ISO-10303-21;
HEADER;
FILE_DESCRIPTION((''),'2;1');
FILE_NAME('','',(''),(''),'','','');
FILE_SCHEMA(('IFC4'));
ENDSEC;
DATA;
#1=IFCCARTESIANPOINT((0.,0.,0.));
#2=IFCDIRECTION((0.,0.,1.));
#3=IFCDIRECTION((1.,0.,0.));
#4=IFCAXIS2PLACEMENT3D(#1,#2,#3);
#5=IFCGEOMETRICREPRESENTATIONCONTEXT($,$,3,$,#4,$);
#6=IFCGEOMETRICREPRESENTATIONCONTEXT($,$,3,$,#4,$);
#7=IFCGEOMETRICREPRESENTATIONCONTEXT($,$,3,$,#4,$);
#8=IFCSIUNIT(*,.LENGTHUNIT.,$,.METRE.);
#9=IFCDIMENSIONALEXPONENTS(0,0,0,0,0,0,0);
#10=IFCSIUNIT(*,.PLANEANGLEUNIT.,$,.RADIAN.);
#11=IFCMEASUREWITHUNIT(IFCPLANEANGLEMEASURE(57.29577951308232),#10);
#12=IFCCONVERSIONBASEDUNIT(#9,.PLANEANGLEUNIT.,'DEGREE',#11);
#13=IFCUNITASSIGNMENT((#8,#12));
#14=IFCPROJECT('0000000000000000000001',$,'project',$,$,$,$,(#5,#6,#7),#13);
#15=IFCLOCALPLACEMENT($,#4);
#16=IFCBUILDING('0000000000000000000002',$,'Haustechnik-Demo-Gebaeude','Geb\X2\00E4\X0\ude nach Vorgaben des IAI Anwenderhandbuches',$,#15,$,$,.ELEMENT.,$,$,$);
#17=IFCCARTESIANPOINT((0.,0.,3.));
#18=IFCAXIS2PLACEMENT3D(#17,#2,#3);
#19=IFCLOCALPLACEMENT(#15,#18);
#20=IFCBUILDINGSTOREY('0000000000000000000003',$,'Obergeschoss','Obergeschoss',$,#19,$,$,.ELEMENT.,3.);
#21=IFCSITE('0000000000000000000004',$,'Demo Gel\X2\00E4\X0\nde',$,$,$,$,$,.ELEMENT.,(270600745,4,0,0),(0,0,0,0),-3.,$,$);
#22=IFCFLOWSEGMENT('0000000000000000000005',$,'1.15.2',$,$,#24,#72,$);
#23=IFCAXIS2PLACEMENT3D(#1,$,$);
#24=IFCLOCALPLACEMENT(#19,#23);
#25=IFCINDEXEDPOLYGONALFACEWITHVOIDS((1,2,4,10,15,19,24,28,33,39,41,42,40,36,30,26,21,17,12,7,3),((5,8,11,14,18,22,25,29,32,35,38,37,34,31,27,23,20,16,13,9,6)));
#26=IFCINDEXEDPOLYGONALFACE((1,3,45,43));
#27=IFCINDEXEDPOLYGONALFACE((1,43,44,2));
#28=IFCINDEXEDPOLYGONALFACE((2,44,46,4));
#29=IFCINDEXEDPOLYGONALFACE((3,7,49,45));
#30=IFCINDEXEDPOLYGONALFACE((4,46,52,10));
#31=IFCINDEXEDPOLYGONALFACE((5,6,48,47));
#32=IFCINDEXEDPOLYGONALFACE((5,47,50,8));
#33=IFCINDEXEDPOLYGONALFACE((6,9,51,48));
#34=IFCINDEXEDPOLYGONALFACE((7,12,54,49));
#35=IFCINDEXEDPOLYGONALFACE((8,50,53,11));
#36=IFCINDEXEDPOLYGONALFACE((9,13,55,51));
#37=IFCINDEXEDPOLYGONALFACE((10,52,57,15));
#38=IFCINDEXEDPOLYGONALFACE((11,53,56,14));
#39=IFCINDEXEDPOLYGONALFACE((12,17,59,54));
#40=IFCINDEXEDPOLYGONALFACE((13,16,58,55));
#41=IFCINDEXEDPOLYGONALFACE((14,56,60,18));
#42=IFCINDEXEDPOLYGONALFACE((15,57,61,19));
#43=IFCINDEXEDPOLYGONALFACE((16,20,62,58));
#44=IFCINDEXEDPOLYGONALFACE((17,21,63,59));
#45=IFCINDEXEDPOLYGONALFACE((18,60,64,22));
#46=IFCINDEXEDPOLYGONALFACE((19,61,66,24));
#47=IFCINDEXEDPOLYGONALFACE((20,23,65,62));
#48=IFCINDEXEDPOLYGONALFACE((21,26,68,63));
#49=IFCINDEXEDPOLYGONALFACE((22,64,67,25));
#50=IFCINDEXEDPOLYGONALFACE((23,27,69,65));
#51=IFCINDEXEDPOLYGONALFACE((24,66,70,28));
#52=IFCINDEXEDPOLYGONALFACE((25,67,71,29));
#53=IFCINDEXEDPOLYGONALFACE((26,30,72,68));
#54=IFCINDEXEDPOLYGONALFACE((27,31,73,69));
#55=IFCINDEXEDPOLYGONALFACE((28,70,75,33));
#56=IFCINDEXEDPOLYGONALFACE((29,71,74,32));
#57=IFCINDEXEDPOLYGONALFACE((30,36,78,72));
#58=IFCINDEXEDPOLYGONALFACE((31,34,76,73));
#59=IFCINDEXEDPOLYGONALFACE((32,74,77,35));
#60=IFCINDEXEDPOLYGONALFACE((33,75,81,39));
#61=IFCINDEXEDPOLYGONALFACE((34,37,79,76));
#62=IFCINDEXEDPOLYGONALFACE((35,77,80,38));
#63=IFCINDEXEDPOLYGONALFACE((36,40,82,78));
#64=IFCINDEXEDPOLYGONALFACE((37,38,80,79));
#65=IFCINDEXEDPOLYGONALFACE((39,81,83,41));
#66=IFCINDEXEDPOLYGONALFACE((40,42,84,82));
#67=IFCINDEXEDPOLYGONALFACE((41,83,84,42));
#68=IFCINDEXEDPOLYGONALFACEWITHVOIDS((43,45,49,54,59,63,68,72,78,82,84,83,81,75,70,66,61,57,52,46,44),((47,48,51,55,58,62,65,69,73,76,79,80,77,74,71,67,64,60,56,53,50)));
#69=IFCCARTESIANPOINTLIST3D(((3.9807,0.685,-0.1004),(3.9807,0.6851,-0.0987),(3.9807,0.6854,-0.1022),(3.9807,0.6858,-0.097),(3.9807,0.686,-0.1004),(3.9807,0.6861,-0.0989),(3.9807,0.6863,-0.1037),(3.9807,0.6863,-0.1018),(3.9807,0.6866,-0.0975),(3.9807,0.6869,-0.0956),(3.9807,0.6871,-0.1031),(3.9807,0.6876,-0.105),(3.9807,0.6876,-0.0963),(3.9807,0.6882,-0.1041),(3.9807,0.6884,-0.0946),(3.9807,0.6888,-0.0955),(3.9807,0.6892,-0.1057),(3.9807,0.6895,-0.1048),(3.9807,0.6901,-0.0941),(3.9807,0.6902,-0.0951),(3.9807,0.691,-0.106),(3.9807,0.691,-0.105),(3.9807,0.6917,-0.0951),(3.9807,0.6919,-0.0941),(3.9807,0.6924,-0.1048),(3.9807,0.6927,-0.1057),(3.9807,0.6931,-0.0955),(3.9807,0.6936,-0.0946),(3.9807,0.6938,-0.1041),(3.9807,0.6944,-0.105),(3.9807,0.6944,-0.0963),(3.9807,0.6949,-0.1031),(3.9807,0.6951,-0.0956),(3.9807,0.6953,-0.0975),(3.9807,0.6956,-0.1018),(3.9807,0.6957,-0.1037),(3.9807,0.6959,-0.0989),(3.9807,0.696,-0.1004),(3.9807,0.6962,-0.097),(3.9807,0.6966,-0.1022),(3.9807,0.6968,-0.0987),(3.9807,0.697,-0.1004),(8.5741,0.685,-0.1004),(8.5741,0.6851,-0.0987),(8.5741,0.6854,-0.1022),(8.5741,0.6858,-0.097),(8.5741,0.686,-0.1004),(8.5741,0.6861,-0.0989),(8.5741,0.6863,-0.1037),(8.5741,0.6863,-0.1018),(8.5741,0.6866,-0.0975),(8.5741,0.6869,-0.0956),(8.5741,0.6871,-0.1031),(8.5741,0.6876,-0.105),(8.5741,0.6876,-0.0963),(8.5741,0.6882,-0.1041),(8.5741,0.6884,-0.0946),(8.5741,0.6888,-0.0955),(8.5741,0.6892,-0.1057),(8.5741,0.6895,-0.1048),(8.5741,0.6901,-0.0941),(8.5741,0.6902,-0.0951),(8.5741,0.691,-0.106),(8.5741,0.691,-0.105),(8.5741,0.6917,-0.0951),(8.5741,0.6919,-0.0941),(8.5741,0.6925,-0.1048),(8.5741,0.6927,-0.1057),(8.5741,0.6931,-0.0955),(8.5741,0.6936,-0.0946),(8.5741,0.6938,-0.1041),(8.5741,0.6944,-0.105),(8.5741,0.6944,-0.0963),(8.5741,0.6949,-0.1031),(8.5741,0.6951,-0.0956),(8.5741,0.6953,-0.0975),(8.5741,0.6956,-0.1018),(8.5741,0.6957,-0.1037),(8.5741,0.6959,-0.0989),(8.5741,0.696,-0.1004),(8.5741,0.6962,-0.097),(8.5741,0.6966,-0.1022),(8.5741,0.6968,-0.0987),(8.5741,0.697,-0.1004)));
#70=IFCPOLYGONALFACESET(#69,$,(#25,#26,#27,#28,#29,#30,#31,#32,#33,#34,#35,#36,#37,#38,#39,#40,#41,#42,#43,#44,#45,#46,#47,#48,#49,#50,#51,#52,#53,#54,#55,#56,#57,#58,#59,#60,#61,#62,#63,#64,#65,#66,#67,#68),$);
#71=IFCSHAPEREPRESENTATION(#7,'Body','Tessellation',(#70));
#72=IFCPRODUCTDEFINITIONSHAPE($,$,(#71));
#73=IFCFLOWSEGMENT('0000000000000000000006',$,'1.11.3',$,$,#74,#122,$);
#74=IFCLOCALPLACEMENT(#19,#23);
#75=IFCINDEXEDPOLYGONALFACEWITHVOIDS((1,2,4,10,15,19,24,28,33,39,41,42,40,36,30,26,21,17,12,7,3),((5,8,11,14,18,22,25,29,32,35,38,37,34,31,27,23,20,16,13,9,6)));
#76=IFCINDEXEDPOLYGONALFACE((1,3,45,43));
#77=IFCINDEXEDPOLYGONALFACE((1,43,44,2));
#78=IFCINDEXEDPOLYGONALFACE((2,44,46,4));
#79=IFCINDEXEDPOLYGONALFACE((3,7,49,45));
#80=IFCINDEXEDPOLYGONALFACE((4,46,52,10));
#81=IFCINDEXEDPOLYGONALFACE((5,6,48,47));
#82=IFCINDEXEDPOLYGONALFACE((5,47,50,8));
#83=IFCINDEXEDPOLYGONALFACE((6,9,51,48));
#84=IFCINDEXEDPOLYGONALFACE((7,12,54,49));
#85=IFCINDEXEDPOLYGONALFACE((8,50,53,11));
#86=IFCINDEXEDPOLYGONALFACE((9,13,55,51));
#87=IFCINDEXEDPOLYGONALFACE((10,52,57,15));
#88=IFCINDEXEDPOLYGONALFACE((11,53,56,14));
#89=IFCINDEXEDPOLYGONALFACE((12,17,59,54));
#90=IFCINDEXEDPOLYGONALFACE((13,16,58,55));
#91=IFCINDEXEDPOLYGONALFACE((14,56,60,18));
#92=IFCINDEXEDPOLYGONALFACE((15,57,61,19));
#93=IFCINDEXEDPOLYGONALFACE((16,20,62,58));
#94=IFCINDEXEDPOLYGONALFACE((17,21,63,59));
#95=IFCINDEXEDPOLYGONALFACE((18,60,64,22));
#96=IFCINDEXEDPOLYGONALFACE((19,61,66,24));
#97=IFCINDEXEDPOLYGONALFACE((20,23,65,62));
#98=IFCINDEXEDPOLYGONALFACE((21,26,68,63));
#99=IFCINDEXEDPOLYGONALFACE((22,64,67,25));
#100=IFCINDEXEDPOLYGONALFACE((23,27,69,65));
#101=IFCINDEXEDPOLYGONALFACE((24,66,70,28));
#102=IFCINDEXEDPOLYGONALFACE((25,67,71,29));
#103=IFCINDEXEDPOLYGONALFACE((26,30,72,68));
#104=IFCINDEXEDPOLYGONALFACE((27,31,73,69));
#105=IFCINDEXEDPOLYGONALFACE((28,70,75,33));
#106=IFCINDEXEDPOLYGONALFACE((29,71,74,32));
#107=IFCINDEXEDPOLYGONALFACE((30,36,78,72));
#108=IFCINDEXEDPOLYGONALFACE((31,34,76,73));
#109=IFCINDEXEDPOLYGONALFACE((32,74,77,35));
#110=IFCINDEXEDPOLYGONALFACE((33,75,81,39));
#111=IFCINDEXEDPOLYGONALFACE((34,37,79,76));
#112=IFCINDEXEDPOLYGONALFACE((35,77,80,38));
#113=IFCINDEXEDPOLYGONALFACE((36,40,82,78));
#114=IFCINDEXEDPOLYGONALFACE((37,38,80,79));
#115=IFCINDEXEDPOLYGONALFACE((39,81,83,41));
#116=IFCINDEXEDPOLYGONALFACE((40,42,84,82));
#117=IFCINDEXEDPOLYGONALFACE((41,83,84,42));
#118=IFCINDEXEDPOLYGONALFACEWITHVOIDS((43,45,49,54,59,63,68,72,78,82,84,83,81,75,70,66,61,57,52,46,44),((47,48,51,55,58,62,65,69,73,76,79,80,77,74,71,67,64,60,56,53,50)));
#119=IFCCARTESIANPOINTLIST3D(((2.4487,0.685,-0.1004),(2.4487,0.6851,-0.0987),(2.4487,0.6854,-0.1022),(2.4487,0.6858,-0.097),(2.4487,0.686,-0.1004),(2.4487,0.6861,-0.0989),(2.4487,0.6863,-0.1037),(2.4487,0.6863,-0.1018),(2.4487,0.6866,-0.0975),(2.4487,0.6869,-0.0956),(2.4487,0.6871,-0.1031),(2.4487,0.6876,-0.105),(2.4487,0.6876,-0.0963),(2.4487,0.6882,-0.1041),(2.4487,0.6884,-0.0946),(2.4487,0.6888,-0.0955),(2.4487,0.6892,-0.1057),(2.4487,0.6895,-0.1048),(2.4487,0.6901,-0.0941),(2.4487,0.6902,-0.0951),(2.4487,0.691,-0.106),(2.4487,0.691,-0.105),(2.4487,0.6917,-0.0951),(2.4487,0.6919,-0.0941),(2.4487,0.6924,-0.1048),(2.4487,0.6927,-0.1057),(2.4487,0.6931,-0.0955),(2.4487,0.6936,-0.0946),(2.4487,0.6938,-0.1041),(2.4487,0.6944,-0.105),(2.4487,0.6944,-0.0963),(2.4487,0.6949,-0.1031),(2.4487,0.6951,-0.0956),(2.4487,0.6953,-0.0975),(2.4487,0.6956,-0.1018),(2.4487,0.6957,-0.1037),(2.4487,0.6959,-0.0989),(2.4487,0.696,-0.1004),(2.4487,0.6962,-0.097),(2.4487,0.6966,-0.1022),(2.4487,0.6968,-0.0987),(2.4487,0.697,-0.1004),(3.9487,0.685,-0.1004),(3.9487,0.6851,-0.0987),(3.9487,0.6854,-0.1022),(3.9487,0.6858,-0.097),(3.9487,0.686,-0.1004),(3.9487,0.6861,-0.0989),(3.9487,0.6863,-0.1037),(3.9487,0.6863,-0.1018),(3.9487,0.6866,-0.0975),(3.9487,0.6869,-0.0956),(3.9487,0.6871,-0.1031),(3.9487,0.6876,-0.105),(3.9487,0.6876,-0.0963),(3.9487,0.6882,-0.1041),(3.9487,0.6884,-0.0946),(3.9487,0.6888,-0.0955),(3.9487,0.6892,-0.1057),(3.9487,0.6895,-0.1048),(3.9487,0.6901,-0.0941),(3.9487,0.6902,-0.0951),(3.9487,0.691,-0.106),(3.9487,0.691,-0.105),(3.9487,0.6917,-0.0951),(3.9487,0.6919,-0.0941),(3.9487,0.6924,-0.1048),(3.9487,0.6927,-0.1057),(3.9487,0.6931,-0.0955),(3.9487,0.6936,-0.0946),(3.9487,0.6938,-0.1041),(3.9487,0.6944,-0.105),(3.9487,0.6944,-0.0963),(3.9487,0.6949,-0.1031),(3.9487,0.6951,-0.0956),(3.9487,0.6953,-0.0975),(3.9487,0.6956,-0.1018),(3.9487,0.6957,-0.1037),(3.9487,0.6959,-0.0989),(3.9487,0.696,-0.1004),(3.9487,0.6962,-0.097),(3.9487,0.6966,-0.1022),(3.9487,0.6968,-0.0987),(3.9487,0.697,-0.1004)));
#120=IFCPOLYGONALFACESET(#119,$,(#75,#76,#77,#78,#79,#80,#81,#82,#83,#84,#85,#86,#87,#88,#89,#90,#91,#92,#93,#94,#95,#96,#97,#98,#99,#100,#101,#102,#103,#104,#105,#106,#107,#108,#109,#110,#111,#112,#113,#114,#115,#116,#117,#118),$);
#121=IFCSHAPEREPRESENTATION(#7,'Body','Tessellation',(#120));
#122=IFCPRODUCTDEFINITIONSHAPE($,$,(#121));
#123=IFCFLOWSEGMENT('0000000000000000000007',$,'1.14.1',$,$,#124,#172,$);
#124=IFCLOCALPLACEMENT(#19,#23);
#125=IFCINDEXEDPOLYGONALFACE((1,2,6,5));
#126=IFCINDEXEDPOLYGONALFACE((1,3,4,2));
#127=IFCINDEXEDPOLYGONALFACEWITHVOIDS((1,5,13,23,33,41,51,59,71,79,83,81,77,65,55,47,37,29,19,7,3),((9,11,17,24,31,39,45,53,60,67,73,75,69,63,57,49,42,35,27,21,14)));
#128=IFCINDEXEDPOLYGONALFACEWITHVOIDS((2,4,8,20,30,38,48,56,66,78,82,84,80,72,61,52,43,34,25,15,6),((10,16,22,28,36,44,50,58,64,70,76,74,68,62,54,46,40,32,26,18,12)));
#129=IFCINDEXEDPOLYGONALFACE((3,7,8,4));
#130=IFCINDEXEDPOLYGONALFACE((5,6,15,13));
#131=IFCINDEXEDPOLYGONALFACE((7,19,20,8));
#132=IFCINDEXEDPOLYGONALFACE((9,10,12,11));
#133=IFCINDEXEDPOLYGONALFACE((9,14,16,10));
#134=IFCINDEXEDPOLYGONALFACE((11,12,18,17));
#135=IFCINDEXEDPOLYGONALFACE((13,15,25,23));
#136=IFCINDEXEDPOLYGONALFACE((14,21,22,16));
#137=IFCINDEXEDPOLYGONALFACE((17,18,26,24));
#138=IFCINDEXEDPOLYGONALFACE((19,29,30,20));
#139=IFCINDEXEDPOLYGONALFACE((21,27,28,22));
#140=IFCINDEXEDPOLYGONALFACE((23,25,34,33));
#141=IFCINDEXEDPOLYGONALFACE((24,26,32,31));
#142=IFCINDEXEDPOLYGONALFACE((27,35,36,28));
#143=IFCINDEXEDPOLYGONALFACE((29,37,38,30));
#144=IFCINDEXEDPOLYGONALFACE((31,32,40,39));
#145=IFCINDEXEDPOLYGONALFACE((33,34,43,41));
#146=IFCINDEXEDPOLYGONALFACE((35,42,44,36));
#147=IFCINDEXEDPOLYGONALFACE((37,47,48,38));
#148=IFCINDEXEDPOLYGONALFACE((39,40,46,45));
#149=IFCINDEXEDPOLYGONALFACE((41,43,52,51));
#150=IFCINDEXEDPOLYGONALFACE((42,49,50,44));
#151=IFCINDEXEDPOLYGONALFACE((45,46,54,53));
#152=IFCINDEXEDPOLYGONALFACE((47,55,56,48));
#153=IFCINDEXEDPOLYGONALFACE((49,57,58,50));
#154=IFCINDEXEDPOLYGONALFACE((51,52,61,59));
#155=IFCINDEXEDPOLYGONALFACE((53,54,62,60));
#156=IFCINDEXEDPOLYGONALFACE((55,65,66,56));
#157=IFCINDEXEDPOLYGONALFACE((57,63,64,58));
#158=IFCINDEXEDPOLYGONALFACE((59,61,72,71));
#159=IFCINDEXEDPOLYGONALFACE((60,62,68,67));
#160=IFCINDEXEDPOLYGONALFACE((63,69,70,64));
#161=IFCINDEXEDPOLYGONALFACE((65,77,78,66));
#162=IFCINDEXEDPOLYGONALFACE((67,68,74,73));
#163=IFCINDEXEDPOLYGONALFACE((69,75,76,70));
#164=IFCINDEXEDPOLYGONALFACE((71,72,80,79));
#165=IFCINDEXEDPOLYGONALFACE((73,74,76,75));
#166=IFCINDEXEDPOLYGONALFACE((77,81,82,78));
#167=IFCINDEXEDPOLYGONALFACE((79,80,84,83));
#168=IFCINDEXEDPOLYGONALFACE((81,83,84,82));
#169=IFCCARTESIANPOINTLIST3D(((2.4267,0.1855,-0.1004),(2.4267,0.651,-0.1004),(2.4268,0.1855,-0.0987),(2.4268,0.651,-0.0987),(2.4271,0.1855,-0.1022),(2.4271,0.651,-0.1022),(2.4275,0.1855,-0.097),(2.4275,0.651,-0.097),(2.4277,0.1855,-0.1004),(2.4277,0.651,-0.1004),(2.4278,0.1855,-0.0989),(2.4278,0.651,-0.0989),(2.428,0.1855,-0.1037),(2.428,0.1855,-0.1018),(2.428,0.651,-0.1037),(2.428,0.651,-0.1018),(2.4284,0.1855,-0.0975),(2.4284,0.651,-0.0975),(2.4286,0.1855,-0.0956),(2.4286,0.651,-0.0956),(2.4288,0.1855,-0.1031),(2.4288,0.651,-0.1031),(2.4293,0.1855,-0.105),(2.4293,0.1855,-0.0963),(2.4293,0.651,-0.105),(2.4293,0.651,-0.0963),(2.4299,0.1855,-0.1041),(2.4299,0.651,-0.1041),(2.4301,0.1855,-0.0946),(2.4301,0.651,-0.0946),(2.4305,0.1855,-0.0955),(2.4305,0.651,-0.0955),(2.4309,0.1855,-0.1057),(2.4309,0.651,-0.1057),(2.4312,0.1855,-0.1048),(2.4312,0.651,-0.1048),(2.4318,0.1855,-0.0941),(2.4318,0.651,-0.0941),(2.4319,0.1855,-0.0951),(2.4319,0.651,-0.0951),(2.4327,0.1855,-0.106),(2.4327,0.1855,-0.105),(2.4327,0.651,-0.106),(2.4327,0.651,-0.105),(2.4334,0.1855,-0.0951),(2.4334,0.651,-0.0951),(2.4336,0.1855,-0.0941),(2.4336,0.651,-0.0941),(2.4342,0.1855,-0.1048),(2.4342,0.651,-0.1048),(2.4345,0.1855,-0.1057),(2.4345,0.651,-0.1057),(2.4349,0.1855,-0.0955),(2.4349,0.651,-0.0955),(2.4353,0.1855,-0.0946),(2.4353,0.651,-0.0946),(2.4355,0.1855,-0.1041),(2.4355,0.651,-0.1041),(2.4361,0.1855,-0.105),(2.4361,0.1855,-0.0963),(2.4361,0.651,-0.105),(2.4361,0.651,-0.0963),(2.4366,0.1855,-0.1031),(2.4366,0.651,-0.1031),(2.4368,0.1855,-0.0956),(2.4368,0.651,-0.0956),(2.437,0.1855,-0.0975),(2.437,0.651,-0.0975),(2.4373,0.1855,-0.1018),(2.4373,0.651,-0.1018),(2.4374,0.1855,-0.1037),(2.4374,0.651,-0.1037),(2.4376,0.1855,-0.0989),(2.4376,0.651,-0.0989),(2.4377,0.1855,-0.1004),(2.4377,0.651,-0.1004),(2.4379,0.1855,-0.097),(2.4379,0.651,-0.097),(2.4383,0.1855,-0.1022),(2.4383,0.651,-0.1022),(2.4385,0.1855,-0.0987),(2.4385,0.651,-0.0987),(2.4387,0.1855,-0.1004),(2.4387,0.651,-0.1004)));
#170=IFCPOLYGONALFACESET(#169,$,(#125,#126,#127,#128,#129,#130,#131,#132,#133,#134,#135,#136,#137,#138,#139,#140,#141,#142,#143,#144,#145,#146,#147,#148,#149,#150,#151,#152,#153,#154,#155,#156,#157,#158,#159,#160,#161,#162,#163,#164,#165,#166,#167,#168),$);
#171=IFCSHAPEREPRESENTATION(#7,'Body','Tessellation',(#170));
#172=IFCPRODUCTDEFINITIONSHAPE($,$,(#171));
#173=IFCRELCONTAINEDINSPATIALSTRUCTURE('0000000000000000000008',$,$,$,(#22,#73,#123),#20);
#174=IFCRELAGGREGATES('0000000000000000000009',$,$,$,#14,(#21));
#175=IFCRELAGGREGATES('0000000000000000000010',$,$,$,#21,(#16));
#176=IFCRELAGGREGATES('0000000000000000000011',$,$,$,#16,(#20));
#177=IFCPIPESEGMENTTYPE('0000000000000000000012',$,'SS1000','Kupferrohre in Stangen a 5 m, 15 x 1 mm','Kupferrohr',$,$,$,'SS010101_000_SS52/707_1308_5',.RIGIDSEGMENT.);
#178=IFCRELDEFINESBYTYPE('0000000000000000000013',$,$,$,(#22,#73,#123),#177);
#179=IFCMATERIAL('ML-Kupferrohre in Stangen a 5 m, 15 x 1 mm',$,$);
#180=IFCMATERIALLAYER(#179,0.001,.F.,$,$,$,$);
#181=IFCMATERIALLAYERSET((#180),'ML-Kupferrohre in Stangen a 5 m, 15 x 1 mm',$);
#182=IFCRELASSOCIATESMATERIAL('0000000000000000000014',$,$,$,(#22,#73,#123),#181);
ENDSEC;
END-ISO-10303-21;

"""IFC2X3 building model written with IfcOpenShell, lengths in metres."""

from ifc_helpers import new_model, entity, si_unit, converted_unit, frame, origin_with_axes, origin_2d_with_axis, place, context, project, spatial, hollow_circle, extrude, material, layer, layer_set, layer_usage, type_object, element, save


model = new_model("IFC2X3")

# Units and contexts
context_of_model_1 = context(None, 3, world=origin_with_axes())
context_of_model_2 = context(None, 3, world=origin_with_axes())
context_of_model_3 = context(None, 3, world=origin_with_axes())
ifc_project = project(units=[si_unit("LENGTHUNIT", "METRE"), converted_unit("PLANEANGLEUNIT", "DEGREE", entity("IfcPlaneAngleMeasure", 57.29577951308232), si_unit("PLANEANGLEUNIT", "RADIAN"), dimensions=[0, 0, 0, 0, 0, 0, 0])], contexts=[context_of_model_1, context_of_model_2, context_of_model_3])

# Site, building, storey
site = spatial("IfcSite", under=ifc_project, Name="Demo Gelände", CompositionType="ELEMENT", RefLatitude=(270600745, 4, 0, 0), RefLongitude=(0, 0, 0, 0), RefElevation=-3.0)
building_placement = place(None, origin_with_axes())
building = spatial("IfcBuilding", under=site, at=building_placement, Name="Haustechnik-Demo-Gebaeude", Description="Gebäude nach Vorgaben des IAI Anwenderhandbuches", CompositionType="ELEMENT")
storey_placement = place(building_placement, frame((0.0, 0.0, 3.0), z_axis=(0.0, 0.0, 1.0), x_axis=(1.0, 0.0, 0.0)))
storey = spatial("IfcBuildingStorey", under=building, at=storey_placement, Name="Obergeschoss", Description="Obergeschoss", CompositionType="ELEMENT", Elevation=3.0)

# Flow segments
ifc_material = material(Name="ML-Kupferrohre in Stangen a 5 m, 15 x 1 mm")
ifc_layer = layer(ifc_material, 0.001, ventilated=False)
ifc_layer_set = layer_set([ifc_layer], Name="ML-Kupferrohre in Stangen a 5 m, 15 x 1 mm")
ifc_layer_usage = layer_usage(ifc_layer_set, "AXIS2", "POSITIVE", 0.0)
pipe_segment_type_1 = type_object("IfcPipeSegmentType", Name="SS1000", Description="Kupferrohre in Stangen a 5 m, 15 x 1 mm", ApplicableOccurrence="Kupferrohr", ElementType="SS010101_000_SS52/707_1308_5", PredefinedType="RIGIDSEGMENT")
flow_segment_1_placement = place(storey_placement, frame((8.5741, 0.691, -0.1), z_axis=(-1.0, 0.0, 0.0), x_axis=(0.0, 0.0, -1.0)))
element("IfcFlowSegment", 1, at=flow_segment_1_placement, inside=storey, type_object=pipe_segment_type_1, material=ifc_layer_usage, Name="1.15.2", context=context_of_model_3, shape_type="SweptSolid", body=[
    extrude(hollow_circle(Radius=0.006, WallThickness=0.001, at=origin_2d_with_axis()), origin_with_axes(), (0.0, 0.0, 1.0), 4.5934),
])
flow_segment_2_placement = place(storey_placement, frame((3.9487, 0.691, -0.1), z_axis=(-1.0, 0.0, 0.0), x_axis=(0.0, 0.0, -1.0)))
element("IfcFlowSegment", 2, at=flow_segment_2_placement, inside=storey, type_object=pipe_segment_type_1, material=ifc_layer_usage, Name="1.11.3", context=context_of_model_3, shape_type="SweptSolid", body=[
    extrude(hollow_circle(Radius=0.006, WallThickness=0.001, at=origin_2d_with_axis()), origin_with_axes(), (0.0, 0.0, 1.0), 1.5),
])
flow_segment_3_placement = place(storey_placement, frame((2.4327, 0.651, -0.1), z_axis=(0.0, -1.0, 0.0), x_axis=(0.0, 0.0, -1.0)))
element("IfcFlowSegment", 3, at=flow_segment_3_placement, inside=storey, type_object=pipe_segment_type_1, material=ifc_layer_usage, Name="1.14.1", context=context_of_model_3, shape_type="SweptSolid", body=[
    extrude(hollow_circle(Radius=0.006, WallThickness=0.001, at=origin_2d_with_axis()), origin_with_axes(), (0.0, 0.0, 1.0), 0.4655),
])

save(model, "model.ifc")
